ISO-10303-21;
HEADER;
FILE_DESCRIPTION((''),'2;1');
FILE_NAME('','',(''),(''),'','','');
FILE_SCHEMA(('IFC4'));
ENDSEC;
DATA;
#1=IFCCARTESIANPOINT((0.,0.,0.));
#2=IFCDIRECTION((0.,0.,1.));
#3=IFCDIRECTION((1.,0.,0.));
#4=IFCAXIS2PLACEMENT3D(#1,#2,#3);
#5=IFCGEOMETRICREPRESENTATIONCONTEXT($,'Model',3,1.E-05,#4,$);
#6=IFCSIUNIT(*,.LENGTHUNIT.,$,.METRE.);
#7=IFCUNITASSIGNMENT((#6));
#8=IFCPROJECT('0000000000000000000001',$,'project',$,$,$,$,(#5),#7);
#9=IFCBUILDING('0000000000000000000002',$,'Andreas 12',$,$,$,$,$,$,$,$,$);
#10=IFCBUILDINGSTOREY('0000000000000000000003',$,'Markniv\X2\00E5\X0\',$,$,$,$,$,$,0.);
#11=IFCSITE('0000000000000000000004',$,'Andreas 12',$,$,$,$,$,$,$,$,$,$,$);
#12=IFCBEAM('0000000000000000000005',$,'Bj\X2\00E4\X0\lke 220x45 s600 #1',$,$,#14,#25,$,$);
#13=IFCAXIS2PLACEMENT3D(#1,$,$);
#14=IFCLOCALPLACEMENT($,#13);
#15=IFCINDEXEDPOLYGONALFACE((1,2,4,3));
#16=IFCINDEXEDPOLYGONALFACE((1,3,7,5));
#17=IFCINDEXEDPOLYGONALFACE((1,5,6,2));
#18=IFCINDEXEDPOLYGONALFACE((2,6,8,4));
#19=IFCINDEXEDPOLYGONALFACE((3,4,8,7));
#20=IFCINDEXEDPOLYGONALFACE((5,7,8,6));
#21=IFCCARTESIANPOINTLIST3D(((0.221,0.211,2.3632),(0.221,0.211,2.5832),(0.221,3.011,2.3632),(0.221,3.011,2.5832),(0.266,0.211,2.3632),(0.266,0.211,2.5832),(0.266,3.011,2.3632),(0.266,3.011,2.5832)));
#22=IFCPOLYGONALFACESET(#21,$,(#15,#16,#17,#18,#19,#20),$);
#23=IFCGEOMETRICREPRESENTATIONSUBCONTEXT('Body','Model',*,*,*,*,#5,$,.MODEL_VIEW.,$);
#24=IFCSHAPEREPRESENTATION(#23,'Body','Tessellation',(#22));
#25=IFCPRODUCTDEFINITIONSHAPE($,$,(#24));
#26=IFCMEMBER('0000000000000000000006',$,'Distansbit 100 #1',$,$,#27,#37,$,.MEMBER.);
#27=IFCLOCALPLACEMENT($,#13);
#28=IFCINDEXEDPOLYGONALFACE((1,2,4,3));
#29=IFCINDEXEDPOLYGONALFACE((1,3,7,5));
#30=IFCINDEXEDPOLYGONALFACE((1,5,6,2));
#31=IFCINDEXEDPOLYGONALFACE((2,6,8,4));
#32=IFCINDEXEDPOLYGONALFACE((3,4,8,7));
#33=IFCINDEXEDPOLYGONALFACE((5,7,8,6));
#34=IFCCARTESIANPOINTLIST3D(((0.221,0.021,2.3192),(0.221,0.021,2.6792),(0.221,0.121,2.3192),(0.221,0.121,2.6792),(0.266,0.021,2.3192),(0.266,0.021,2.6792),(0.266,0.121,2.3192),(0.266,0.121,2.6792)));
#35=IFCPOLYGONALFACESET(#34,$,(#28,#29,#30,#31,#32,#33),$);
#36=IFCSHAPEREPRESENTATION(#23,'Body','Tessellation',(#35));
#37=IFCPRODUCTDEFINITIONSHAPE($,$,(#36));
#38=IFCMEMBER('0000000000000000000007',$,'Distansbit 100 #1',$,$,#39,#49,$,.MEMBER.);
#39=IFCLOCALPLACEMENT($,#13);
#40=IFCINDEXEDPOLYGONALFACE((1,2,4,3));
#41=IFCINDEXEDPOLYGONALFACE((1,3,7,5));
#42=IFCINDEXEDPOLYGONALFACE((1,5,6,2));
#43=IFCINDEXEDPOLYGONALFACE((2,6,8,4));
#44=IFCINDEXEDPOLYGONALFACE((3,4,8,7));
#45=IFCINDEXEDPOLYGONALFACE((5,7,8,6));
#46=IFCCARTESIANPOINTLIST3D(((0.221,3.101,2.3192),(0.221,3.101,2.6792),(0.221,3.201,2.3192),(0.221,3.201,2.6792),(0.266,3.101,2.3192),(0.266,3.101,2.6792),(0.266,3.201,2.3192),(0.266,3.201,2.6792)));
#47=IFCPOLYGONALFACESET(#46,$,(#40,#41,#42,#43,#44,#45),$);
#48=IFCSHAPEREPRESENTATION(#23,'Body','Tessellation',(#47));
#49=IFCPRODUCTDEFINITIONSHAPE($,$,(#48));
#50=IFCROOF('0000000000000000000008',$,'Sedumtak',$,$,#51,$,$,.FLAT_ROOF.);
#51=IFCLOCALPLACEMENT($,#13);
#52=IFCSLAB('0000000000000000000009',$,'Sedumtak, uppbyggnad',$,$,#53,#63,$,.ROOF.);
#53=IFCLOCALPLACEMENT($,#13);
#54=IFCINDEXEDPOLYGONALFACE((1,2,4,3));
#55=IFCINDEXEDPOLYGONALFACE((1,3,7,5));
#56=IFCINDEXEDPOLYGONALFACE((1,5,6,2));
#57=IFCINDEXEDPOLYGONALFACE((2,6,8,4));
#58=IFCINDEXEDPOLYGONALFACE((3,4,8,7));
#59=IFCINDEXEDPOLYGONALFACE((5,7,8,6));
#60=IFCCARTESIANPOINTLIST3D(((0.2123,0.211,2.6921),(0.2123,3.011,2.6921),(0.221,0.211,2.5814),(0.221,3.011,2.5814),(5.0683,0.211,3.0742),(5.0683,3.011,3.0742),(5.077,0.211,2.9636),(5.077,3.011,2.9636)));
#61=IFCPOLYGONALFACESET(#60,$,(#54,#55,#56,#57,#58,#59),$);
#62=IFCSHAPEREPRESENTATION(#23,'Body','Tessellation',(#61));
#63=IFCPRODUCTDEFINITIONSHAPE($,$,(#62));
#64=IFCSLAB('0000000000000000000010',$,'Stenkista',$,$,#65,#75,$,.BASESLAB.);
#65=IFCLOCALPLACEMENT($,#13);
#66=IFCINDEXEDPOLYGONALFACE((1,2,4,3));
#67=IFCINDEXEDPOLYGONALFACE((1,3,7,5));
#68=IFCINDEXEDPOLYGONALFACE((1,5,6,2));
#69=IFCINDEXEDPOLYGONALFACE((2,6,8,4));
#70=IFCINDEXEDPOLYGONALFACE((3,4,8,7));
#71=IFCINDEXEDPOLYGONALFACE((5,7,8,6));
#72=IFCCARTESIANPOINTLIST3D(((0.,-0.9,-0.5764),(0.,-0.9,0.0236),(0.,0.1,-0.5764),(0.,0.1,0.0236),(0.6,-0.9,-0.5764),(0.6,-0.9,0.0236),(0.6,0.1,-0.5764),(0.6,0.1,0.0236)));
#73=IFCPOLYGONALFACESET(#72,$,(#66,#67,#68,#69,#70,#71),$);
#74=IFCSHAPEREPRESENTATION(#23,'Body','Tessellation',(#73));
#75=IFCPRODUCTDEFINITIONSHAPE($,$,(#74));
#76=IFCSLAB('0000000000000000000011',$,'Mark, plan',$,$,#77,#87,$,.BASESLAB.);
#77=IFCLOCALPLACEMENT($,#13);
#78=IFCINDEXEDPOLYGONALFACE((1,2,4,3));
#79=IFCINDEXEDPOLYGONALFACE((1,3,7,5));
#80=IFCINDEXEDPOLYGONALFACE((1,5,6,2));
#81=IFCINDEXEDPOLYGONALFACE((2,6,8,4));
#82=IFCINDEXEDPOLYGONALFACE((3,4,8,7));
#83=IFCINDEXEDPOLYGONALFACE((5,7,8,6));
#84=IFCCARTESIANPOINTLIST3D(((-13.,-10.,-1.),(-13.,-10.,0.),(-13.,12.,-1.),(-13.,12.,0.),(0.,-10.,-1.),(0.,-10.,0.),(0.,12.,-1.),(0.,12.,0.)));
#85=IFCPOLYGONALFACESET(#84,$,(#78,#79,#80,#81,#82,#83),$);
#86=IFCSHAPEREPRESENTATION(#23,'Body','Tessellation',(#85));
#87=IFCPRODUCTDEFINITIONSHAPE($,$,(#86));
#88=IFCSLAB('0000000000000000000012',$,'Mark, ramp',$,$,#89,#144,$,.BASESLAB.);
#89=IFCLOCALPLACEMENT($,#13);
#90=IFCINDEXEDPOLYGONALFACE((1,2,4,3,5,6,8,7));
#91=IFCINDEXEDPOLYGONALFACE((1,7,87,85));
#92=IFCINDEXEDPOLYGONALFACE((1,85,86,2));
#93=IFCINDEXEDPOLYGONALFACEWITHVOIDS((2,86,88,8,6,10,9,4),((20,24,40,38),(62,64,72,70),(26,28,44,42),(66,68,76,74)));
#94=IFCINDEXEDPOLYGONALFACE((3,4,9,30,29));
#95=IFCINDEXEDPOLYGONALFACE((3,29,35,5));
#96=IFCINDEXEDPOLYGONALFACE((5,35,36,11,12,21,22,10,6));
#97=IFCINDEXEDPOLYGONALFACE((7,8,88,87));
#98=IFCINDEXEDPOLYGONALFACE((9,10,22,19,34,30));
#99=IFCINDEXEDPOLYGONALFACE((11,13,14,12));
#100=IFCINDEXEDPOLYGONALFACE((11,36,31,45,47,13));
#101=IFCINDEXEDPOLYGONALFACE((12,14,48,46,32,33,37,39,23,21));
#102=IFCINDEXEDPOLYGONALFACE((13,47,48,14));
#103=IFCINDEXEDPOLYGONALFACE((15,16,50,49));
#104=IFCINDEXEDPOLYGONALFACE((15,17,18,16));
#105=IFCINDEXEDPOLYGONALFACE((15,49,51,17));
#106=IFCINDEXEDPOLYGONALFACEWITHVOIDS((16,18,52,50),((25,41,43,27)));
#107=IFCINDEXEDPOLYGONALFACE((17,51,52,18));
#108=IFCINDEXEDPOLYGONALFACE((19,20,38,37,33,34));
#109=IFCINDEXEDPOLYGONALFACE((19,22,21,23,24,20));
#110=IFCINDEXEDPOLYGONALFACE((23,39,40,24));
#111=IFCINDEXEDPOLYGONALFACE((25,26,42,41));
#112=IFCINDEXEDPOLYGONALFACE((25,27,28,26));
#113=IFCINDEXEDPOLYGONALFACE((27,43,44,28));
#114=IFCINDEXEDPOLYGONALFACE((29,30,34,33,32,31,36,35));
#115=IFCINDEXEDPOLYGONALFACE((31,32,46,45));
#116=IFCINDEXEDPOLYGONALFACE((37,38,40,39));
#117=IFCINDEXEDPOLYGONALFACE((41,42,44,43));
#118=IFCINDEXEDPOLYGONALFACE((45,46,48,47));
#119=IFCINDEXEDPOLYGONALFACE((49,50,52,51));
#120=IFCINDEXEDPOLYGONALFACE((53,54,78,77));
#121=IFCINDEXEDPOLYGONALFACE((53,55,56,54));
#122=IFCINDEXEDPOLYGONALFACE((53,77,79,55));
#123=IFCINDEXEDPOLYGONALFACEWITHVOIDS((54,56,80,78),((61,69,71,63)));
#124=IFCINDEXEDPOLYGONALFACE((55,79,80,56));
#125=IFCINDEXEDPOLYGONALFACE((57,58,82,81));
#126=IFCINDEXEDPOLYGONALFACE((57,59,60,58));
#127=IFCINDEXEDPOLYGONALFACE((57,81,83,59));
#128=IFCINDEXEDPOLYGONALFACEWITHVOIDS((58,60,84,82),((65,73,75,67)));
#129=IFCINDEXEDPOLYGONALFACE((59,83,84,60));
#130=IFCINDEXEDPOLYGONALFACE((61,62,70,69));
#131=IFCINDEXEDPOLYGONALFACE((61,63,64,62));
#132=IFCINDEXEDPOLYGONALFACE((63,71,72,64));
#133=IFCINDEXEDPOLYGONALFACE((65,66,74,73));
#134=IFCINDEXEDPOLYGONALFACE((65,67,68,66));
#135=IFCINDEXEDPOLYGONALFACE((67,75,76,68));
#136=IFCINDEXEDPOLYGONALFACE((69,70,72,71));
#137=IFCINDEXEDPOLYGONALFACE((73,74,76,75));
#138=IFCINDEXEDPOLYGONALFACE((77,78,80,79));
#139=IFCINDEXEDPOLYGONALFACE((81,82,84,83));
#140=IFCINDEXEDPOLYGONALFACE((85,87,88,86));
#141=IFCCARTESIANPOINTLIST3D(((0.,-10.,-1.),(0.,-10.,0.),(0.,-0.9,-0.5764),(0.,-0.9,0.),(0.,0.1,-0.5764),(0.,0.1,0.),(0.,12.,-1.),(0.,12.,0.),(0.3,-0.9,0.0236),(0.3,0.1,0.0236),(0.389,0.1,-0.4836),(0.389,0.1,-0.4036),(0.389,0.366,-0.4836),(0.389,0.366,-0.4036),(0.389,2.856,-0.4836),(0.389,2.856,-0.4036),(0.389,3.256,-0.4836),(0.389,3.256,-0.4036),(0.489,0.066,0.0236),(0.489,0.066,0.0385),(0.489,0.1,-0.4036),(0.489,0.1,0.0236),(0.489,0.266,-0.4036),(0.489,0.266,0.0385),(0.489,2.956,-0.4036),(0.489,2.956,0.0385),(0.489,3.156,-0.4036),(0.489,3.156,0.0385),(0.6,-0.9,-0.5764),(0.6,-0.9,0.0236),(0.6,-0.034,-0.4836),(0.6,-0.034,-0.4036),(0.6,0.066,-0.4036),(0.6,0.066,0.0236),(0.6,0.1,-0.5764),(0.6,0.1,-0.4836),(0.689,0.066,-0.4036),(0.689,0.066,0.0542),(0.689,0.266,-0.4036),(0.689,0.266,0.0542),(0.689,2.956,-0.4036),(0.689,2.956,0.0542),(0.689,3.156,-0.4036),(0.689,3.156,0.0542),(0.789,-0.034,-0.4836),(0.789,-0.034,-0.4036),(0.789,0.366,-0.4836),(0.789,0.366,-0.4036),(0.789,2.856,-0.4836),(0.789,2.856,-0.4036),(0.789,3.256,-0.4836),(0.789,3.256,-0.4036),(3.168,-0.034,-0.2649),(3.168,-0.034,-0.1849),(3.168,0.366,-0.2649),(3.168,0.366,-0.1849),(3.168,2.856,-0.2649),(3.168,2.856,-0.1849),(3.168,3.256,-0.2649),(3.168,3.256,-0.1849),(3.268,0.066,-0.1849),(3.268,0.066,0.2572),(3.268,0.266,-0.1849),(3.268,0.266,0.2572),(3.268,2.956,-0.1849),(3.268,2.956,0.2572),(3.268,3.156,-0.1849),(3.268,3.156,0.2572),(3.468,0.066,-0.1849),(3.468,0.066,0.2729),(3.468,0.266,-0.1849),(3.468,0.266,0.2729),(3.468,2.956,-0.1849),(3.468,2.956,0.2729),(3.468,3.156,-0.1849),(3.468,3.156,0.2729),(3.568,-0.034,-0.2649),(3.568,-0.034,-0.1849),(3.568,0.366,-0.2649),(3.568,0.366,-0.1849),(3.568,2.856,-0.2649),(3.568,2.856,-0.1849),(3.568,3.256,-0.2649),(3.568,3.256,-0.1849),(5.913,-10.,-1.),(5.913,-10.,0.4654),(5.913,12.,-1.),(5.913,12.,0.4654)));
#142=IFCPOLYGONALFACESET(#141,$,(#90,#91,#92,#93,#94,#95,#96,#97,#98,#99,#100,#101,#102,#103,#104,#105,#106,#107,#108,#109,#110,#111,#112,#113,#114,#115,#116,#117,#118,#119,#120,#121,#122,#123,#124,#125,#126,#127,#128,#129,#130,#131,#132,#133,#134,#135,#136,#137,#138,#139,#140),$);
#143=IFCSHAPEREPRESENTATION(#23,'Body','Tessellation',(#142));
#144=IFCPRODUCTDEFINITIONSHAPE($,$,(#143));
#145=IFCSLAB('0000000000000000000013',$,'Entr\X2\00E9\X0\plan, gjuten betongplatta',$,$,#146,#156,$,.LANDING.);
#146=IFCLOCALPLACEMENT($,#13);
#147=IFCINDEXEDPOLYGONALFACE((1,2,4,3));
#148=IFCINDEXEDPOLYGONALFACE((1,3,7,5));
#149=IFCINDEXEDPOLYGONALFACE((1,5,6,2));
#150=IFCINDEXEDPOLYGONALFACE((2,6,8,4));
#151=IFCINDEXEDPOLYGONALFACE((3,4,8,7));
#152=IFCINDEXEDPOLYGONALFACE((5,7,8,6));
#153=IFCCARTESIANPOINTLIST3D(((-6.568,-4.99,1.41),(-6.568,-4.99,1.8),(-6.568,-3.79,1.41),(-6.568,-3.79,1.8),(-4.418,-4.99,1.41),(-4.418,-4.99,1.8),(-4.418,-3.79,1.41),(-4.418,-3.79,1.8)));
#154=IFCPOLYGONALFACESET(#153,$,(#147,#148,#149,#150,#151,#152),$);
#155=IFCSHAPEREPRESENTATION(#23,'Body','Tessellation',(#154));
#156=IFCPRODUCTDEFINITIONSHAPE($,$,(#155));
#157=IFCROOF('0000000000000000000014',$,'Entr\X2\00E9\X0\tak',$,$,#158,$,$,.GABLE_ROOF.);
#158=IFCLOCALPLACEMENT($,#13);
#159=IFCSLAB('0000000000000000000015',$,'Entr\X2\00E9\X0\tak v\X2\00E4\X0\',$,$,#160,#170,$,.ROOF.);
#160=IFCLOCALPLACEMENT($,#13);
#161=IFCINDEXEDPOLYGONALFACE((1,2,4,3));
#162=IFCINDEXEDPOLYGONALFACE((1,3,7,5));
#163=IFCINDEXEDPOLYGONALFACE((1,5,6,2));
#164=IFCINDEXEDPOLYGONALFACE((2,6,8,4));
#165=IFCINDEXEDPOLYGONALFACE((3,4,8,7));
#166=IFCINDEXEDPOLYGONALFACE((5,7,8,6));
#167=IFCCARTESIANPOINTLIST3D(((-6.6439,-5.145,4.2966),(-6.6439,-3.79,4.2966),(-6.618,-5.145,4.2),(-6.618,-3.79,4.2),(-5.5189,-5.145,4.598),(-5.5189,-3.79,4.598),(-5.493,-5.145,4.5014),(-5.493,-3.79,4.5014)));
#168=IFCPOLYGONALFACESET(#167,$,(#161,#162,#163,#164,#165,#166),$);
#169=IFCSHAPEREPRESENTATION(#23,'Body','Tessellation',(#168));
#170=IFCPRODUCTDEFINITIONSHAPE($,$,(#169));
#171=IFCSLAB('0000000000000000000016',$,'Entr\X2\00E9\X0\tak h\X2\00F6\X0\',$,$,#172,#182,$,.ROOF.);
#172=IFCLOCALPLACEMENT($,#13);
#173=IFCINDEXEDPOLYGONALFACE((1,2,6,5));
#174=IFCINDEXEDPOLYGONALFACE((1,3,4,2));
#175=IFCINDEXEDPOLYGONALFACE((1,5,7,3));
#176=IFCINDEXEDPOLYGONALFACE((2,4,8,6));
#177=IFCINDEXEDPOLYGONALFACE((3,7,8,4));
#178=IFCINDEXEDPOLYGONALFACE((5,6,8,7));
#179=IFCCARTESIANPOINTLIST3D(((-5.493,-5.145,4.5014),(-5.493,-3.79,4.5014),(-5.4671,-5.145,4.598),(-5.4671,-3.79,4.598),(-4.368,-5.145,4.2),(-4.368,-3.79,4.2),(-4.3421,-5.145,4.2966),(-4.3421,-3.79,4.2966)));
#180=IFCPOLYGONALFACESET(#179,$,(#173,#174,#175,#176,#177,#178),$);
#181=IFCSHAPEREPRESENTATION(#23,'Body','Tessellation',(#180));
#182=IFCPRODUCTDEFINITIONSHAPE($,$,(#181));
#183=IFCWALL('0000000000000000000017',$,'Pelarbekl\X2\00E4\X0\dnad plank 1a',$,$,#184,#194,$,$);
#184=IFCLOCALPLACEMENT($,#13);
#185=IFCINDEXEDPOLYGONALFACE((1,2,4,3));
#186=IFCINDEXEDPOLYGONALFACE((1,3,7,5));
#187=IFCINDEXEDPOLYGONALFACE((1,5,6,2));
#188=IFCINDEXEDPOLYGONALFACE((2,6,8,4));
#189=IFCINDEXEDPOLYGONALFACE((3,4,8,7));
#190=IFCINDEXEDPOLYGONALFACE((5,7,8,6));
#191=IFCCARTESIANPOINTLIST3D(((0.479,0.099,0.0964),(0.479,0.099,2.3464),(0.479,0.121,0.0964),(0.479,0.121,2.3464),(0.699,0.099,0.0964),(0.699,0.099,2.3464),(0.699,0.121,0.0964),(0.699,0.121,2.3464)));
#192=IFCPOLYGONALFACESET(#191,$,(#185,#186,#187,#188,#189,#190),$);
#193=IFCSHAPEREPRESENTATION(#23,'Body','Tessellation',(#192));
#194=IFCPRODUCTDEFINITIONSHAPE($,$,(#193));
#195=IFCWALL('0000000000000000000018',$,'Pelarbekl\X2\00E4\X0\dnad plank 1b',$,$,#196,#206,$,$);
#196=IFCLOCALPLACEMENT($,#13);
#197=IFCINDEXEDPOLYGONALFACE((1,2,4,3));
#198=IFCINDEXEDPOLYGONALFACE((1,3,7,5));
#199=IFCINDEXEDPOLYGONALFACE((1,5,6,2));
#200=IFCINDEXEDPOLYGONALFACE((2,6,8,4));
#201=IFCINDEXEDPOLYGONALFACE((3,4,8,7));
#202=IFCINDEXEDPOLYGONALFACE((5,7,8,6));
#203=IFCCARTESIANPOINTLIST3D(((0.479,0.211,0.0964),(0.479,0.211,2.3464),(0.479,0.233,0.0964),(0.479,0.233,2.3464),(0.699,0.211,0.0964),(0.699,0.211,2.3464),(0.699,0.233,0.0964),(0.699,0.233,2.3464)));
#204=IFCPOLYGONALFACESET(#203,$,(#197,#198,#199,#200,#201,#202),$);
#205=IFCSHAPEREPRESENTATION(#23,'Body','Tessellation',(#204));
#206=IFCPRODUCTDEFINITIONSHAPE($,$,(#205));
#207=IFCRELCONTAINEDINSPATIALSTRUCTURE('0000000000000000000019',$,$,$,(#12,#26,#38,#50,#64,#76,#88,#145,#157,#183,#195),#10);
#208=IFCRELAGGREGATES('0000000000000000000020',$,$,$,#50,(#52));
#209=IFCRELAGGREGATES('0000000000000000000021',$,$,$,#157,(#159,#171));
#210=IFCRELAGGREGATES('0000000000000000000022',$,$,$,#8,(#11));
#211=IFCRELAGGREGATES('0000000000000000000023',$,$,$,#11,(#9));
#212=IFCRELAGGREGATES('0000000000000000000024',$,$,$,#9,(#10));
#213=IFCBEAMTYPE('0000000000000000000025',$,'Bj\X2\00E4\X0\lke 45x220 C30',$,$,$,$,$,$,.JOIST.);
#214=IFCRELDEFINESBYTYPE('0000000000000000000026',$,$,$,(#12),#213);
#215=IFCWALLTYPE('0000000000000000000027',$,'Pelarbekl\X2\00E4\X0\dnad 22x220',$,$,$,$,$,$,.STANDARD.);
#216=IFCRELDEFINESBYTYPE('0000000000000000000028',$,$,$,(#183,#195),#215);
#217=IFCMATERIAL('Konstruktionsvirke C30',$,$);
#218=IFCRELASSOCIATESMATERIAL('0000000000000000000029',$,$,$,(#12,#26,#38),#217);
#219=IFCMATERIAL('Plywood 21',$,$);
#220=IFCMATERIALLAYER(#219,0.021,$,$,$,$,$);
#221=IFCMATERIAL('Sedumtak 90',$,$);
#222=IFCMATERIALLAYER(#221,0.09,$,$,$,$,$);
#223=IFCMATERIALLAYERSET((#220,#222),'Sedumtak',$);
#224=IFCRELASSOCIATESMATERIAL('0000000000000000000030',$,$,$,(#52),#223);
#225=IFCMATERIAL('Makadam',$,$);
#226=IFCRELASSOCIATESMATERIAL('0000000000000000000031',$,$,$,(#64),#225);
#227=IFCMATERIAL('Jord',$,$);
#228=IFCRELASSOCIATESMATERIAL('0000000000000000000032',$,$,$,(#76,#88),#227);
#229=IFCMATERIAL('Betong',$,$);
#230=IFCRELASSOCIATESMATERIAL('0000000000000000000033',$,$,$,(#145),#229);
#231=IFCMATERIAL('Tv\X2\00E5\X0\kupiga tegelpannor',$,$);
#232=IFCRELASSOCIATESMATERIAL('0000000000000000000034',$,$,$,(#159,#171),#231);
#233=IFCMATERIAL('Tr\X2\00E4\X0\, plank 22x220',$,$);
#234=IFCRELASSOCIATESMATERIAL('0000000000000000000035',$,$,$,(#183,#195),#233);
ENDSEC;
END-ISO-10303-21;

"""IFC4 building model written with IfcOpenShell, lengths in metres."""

from ifc_helpers import new_model, si_unit, frame, frame_2d, origin, origin_with_axes, origin_2d, place, context, subcontext, project, spatial, rectangle, extrude, boolean, clip, halfspace, material, layer, layer_set, layer_usage, type_object, element, aggregate, save


model = new_model("IFC4")

# Units and contexts
model_context = context("Model", 3, precision=1e-05, world=origin_with_axes())
body_context = subcontext(model_context, "Body", "Model", "MODEL_VIEW")
ifc_project = project(units=[si_unit("LENGTHUNIT", "METRE")], contexts=[model_context])

# Site, building, storey
site = spatial("IfcSite", under=ifc_project, Name="Andreas 12")
building = spatial("IfcBuilding", under=site, Name="Andreas 12")
storey = spatial("IfcBuildingStorey", under=building, Name="Marknivå", Elevation=0.0)

# Shared definitions
ifc_material_1 = material(Name="Betong")

# Beam
ifc_material_2 = material(Name="Konstruktionsvirke C30")
beam_type_1 = type_object("IfcBeamType", Name="Bjälke 45x220 C30", PredefinedType="JOIST")
beam_placement = place(None, frame((0.2435, 0.211, 2.4732), z_axis=(0.0, 1.0, 0.0), x_axis=(1.0, 0.0, 0.0)))
element("IfcBeam", 1, at=beam_placement, inside=storey, type_object=beam_type_1, material=ifc_material_2, Name="Bjälke 220x45 s600 #1", context=body_context, shape_type="SweptSolid", body=[
    extrude(rectangle(XDim=0.045, YDim=0.22, at=origin_2d()), origin(), (0.0, 0.0, 1.0), 2.8),
])

# Members
for number, where, z_axis, x_axis, name in (
    (2, (0.2435, 0.071, 2.3192), (0.0, 0.0, 1.0), (1.0, 0.0, 0.0), "Distansbit 100 #1"),
    (3, (0.2435, 3.151, 2.3192), (0.0, 0.0, 1.0), (1.0, 0.0, 0.0), "Distansbit 100 #1"),
):
    element("IfcMember", number, at=place(None, frame(where, z_axis=z_axis, x_axis=x_axis)), inside=storey, material=ifc_material_2, Name=name, PredefinedType="MEMBER", context=body_context, shape_type="SweptSolid", body=[
        extrude(rectangle(XDim=0.045, YDim=0.1, at=origin_2d()), origin(), (0.0, 0.0, 1.0), 0.36),
    ])

# Roof, slab
roof_1 = element("IfcRoof", 4, inside=storey, Name="Sedumtak", PredefinedType="FLAT_ROOF")
ifc_material_3 = material(Name="Plywood 21")
ifc_layer_1 = layer(ifc_material_3, 0.021)
ifc_material_4 = material(Name="Sedumtak 90")
ifc_layer_2 = layer(ifc_material_4, 0.09)
ifc_layer_set_1 = layer_set([ifc_layer_1, ifc_layer_2], Name="Sedumtak")
ifc_layer_usage_1 = layer_usage(ifc_layer_set_1, "AXIS3", "POSITIVE", 0.0)
slab_1_placement = place(None, frame((0.221, 0.211, 2.5814), z_axis=(-0.078459, 0.0, 0.996917), x_axis=(0.996917, 0.0, 0.078459)))
slab_1 = element("IfcSlab", 5, at=slab_1_placement, material=ifc_layer_usage_1, Name="Sedumtak, uppbyggnad", PredefinedType="ROOF", context=body_context, shape_type="SweptSolid", body=[
    extrude(rectangle(XDim=4.871, YDim=2.8, at=frame_2d((2.4355, 1.4))), origin(), (0.0, 0.0, 1.0), 0.111),
])
aggregate(roof_1, [slab_1])

# Slabs
ifc_material_5 = material(Name="Makadam")
slab_2_placement = place(None, frame((0.0, -0.9, -0.5764), z_axis=(0.0, 0.0, 1.0), x_axis=(1.0, 0.0, 0.0)))
element("IfcSlab", 6, at=slab_2_placement, inside=storey, material=ifc_material_5, Name="Stenkista", PredefinedType="BASESLAB", context=body_context, shape_type="SweptSolid", body=[
    extrude(rectangle(XDim=0.6, YDim=1.0, at=frame_2d((0.3, 0.5))), origin(), (0.0, 0.0, 1.0), 0.6),
])
ifc_material_6 = material(Name="Jord")
slab_3_placement = place(None, origin_with_axes())
element("IfcSlab", 7, at=slab_3_placement, inside=storey, material=ifc_material_6, Name="Mark, plan", PredefinedType="BASESLAB", context=body_context, shape_type="SweptSolid", body=[
    extrude(rectangle(XDim=13.0, YDim=22.0, at=frame_2d((6.5, 11.0))), frame((-13.0, -10.0, -1.0)), (0.0, 0.0, 1.0), 1.0),
])
slab_4_placement = place(None, origin_with_axes())
solid = boolean("DIFFERENCE", boolean("DIFFERENCE", boolean("DIFFERENCE", boolean("DIFFERENCE", boolean("DIFFERENCE", boolean("DIFFERENCE", boolean("DIFFERENCE", clip(extrude(rectangle(XDim=5.913, YDim=22.0, at=frame_2d((2.9565, 11.0))), frame((0.0, -10.0, -1.0)), (0.0, 0.0, 1.0), 1.5654), halfspace(frame((0.0, 0.0, 0.0), z_axis=(-0.078459, 0.0, 0.996917), x_axis=(0.996917, 0.0, 0.078459)), False)), extrude(rectangle(XDim=0.2, YDim=0.2, at=frame_2d((0.1, 0.1))), frame((0.489, 0.066, -0.4036)), (0.0, 0.0, 1.0), 0.5)), extrude(rectangle(XDim=0.4, YDim=0.4, at=frame_2d((0.2, 0.2))), frame((0.389, -0.034, -0.4836)), (0.0, 0.0, 1.0), 0.08)), extrude(rectangle(XDim=0.2, YDim=0.2, at=frame_2d((0.1, 0.1))), frame((0.489, 2.956, -0.4036)), (0.0, 0.0, 1.0), 0.5)), extrude(rectangle(XDim=0.4, YDim=0.4, at=frame_2d((0.2, 0.2))), frame((0.389, 2.856, -0.4836)), (0.0, 0.0, 1.0), 0.08)), extrude(rectangle(XDim=0.2, YDim=0.2, at=frame_2d((0.1, 0.1))), frame((3.268, 0.066, -0.1849)), (0.0, 0.0, 1.0), 0.5)), extrude(rectangle(XDim=0.4, YDim=0.4, at=frame_2d((0.2, 0.2))), frame((3.168, -0.034, -0.2649)), (0.0, 0.0, 1.0), 0.08)), extrude(rectangle(XDim=0.2, YDim=0.2, at=frame_2d((0.1, 0.1))), frame((3.268, 2.956, -0.1849)), (0.0, 0.0, 1.0), 0.5))
element("IfcSlab", 8, at=slab_4_placement, inside=storey, material=ifc_material_6, Name="Mark, ramp", PredefinedType="BASESLAB", context=body_context, shape_type="CSG", body=[
    boolean("DIFFERENCE", boolean("DIFFERENCE", solid, extrude(rectangle(XDim=0.4, YDim=0.4, at=frame_2d((0.2, 0.2))), frame((3.168, 2.856, -0.2649)), (0.0, 0.0, 1.0), 0.08)), extrude(rectangle(XDim=0.6, YDim=1.0, at=frame_2d((0.3, 0.5))), frame((0.0, -0.9, -0.5764)), (0.0, 0.0, 1.0), 0.6)),
])
slab_5_placement = place(None, frame((-6.568, -4.99, 1.41), z_axis=(0.0, 0.0, 1.0), x_axis=(1.0, 0.0, 0.0)))
element("IfcSlab", 9, at=slab_5_placement, inside=storey, material=ifc_material_1, Name="Entréplan, gjuten betongplatta", PredefinedType="LANDING", context=body_context, shape_type="SweptSolid", body=[
    extrude(rectangle(XDim=2.15, YDim=1.2, at=frame_2d((1.075, 0.6))), origin(), (0.0, 0.0, 1.0), 0.39),
])

# Roof, slabs
roof_2 = element("IfcRoof", 10, inside=storey, Name="Entrétak", PredefinedType="GABLE_ROOF")
ifc_material_7 = material(Name="Tvåkupiga tegelpannor")
slab_6_placement = place(None, frame((-6.618, -5.145, 4.2), z_axis=(-0.258819, 0.0, 0.965926), x_axis=(0.965926, 0.0, 0.258819)))
slab_6 = element("IfcSlab", 11, at=slab_6_placement, material=ifc_material_7, Name="Entrétak vä", PredefinedType="ROOF", context=body_context, shape_type="SweptSolid", body=[
    extrude(rectangle(XDim=1.1647, YDim=1.355, at=frame_2d((0.5823, 0.6775))), origin(), (0.0, 0.0, 1.0), 0.1),
])
slab_7_placement = place(None, frame((-5.493, -5.145, 4.5014), z_axis=(0.258819, 0.0, 0.965926), x_axis=(0.965926, 0.0, -0.258819)))
slab_7 = element("IfcSlab", 12, at=slab_7_placement, material=ifc_material_7, Name="Entrétak hö", PredefinedType="ROOF", context=body_context, shape_type="SweptSolid", body=[
    extrude(rectangle(XDim=1.1647, YDim=1.355, at=frame_2d((0.5823, 0.6775))), origin(), (0.0, 0.0, 1.0), 0.1),
])
aggregate(roof_2, [slab_6, slab_7])

# Walls
ifc_material_8 = material(Name="Trä, plank 22x220")
wall_type_1 = type_object("IfcWallType", Name="Pelarbeklädnad 22x220", PredefinedType="STANDARD")
for number, where, z_axis, x_axis, name in (
    (13, (0.589, 0.11, 0.0964), (0.0, 0.0, 1.0), (1.0, 0.0, 0.0), "Pelarbeklädnad plank 1a"),
    (14, (0.589, 0.222, 0.0964), (0.0, 0.0, 1.0), (1.0, 0.0, 0.0), "Pelarbeklädnad plank 1b"),
):
    element("IfcWall", number, at=place(None, frame(where, z_axis=z_axis, x_axis=x_axis)), inside=storey, type_object=wall_type_1, material=ifc_material_8, Name=name, context=body_context, shape_type="SweptSolid", body=[
        extrude(rectangle(XDim=0.22, YDim=0.022, at=origin_2d()), origin(), (0.0, 0.0, 1.0), 2.25),
    ])

save(model, "model.ifc")
